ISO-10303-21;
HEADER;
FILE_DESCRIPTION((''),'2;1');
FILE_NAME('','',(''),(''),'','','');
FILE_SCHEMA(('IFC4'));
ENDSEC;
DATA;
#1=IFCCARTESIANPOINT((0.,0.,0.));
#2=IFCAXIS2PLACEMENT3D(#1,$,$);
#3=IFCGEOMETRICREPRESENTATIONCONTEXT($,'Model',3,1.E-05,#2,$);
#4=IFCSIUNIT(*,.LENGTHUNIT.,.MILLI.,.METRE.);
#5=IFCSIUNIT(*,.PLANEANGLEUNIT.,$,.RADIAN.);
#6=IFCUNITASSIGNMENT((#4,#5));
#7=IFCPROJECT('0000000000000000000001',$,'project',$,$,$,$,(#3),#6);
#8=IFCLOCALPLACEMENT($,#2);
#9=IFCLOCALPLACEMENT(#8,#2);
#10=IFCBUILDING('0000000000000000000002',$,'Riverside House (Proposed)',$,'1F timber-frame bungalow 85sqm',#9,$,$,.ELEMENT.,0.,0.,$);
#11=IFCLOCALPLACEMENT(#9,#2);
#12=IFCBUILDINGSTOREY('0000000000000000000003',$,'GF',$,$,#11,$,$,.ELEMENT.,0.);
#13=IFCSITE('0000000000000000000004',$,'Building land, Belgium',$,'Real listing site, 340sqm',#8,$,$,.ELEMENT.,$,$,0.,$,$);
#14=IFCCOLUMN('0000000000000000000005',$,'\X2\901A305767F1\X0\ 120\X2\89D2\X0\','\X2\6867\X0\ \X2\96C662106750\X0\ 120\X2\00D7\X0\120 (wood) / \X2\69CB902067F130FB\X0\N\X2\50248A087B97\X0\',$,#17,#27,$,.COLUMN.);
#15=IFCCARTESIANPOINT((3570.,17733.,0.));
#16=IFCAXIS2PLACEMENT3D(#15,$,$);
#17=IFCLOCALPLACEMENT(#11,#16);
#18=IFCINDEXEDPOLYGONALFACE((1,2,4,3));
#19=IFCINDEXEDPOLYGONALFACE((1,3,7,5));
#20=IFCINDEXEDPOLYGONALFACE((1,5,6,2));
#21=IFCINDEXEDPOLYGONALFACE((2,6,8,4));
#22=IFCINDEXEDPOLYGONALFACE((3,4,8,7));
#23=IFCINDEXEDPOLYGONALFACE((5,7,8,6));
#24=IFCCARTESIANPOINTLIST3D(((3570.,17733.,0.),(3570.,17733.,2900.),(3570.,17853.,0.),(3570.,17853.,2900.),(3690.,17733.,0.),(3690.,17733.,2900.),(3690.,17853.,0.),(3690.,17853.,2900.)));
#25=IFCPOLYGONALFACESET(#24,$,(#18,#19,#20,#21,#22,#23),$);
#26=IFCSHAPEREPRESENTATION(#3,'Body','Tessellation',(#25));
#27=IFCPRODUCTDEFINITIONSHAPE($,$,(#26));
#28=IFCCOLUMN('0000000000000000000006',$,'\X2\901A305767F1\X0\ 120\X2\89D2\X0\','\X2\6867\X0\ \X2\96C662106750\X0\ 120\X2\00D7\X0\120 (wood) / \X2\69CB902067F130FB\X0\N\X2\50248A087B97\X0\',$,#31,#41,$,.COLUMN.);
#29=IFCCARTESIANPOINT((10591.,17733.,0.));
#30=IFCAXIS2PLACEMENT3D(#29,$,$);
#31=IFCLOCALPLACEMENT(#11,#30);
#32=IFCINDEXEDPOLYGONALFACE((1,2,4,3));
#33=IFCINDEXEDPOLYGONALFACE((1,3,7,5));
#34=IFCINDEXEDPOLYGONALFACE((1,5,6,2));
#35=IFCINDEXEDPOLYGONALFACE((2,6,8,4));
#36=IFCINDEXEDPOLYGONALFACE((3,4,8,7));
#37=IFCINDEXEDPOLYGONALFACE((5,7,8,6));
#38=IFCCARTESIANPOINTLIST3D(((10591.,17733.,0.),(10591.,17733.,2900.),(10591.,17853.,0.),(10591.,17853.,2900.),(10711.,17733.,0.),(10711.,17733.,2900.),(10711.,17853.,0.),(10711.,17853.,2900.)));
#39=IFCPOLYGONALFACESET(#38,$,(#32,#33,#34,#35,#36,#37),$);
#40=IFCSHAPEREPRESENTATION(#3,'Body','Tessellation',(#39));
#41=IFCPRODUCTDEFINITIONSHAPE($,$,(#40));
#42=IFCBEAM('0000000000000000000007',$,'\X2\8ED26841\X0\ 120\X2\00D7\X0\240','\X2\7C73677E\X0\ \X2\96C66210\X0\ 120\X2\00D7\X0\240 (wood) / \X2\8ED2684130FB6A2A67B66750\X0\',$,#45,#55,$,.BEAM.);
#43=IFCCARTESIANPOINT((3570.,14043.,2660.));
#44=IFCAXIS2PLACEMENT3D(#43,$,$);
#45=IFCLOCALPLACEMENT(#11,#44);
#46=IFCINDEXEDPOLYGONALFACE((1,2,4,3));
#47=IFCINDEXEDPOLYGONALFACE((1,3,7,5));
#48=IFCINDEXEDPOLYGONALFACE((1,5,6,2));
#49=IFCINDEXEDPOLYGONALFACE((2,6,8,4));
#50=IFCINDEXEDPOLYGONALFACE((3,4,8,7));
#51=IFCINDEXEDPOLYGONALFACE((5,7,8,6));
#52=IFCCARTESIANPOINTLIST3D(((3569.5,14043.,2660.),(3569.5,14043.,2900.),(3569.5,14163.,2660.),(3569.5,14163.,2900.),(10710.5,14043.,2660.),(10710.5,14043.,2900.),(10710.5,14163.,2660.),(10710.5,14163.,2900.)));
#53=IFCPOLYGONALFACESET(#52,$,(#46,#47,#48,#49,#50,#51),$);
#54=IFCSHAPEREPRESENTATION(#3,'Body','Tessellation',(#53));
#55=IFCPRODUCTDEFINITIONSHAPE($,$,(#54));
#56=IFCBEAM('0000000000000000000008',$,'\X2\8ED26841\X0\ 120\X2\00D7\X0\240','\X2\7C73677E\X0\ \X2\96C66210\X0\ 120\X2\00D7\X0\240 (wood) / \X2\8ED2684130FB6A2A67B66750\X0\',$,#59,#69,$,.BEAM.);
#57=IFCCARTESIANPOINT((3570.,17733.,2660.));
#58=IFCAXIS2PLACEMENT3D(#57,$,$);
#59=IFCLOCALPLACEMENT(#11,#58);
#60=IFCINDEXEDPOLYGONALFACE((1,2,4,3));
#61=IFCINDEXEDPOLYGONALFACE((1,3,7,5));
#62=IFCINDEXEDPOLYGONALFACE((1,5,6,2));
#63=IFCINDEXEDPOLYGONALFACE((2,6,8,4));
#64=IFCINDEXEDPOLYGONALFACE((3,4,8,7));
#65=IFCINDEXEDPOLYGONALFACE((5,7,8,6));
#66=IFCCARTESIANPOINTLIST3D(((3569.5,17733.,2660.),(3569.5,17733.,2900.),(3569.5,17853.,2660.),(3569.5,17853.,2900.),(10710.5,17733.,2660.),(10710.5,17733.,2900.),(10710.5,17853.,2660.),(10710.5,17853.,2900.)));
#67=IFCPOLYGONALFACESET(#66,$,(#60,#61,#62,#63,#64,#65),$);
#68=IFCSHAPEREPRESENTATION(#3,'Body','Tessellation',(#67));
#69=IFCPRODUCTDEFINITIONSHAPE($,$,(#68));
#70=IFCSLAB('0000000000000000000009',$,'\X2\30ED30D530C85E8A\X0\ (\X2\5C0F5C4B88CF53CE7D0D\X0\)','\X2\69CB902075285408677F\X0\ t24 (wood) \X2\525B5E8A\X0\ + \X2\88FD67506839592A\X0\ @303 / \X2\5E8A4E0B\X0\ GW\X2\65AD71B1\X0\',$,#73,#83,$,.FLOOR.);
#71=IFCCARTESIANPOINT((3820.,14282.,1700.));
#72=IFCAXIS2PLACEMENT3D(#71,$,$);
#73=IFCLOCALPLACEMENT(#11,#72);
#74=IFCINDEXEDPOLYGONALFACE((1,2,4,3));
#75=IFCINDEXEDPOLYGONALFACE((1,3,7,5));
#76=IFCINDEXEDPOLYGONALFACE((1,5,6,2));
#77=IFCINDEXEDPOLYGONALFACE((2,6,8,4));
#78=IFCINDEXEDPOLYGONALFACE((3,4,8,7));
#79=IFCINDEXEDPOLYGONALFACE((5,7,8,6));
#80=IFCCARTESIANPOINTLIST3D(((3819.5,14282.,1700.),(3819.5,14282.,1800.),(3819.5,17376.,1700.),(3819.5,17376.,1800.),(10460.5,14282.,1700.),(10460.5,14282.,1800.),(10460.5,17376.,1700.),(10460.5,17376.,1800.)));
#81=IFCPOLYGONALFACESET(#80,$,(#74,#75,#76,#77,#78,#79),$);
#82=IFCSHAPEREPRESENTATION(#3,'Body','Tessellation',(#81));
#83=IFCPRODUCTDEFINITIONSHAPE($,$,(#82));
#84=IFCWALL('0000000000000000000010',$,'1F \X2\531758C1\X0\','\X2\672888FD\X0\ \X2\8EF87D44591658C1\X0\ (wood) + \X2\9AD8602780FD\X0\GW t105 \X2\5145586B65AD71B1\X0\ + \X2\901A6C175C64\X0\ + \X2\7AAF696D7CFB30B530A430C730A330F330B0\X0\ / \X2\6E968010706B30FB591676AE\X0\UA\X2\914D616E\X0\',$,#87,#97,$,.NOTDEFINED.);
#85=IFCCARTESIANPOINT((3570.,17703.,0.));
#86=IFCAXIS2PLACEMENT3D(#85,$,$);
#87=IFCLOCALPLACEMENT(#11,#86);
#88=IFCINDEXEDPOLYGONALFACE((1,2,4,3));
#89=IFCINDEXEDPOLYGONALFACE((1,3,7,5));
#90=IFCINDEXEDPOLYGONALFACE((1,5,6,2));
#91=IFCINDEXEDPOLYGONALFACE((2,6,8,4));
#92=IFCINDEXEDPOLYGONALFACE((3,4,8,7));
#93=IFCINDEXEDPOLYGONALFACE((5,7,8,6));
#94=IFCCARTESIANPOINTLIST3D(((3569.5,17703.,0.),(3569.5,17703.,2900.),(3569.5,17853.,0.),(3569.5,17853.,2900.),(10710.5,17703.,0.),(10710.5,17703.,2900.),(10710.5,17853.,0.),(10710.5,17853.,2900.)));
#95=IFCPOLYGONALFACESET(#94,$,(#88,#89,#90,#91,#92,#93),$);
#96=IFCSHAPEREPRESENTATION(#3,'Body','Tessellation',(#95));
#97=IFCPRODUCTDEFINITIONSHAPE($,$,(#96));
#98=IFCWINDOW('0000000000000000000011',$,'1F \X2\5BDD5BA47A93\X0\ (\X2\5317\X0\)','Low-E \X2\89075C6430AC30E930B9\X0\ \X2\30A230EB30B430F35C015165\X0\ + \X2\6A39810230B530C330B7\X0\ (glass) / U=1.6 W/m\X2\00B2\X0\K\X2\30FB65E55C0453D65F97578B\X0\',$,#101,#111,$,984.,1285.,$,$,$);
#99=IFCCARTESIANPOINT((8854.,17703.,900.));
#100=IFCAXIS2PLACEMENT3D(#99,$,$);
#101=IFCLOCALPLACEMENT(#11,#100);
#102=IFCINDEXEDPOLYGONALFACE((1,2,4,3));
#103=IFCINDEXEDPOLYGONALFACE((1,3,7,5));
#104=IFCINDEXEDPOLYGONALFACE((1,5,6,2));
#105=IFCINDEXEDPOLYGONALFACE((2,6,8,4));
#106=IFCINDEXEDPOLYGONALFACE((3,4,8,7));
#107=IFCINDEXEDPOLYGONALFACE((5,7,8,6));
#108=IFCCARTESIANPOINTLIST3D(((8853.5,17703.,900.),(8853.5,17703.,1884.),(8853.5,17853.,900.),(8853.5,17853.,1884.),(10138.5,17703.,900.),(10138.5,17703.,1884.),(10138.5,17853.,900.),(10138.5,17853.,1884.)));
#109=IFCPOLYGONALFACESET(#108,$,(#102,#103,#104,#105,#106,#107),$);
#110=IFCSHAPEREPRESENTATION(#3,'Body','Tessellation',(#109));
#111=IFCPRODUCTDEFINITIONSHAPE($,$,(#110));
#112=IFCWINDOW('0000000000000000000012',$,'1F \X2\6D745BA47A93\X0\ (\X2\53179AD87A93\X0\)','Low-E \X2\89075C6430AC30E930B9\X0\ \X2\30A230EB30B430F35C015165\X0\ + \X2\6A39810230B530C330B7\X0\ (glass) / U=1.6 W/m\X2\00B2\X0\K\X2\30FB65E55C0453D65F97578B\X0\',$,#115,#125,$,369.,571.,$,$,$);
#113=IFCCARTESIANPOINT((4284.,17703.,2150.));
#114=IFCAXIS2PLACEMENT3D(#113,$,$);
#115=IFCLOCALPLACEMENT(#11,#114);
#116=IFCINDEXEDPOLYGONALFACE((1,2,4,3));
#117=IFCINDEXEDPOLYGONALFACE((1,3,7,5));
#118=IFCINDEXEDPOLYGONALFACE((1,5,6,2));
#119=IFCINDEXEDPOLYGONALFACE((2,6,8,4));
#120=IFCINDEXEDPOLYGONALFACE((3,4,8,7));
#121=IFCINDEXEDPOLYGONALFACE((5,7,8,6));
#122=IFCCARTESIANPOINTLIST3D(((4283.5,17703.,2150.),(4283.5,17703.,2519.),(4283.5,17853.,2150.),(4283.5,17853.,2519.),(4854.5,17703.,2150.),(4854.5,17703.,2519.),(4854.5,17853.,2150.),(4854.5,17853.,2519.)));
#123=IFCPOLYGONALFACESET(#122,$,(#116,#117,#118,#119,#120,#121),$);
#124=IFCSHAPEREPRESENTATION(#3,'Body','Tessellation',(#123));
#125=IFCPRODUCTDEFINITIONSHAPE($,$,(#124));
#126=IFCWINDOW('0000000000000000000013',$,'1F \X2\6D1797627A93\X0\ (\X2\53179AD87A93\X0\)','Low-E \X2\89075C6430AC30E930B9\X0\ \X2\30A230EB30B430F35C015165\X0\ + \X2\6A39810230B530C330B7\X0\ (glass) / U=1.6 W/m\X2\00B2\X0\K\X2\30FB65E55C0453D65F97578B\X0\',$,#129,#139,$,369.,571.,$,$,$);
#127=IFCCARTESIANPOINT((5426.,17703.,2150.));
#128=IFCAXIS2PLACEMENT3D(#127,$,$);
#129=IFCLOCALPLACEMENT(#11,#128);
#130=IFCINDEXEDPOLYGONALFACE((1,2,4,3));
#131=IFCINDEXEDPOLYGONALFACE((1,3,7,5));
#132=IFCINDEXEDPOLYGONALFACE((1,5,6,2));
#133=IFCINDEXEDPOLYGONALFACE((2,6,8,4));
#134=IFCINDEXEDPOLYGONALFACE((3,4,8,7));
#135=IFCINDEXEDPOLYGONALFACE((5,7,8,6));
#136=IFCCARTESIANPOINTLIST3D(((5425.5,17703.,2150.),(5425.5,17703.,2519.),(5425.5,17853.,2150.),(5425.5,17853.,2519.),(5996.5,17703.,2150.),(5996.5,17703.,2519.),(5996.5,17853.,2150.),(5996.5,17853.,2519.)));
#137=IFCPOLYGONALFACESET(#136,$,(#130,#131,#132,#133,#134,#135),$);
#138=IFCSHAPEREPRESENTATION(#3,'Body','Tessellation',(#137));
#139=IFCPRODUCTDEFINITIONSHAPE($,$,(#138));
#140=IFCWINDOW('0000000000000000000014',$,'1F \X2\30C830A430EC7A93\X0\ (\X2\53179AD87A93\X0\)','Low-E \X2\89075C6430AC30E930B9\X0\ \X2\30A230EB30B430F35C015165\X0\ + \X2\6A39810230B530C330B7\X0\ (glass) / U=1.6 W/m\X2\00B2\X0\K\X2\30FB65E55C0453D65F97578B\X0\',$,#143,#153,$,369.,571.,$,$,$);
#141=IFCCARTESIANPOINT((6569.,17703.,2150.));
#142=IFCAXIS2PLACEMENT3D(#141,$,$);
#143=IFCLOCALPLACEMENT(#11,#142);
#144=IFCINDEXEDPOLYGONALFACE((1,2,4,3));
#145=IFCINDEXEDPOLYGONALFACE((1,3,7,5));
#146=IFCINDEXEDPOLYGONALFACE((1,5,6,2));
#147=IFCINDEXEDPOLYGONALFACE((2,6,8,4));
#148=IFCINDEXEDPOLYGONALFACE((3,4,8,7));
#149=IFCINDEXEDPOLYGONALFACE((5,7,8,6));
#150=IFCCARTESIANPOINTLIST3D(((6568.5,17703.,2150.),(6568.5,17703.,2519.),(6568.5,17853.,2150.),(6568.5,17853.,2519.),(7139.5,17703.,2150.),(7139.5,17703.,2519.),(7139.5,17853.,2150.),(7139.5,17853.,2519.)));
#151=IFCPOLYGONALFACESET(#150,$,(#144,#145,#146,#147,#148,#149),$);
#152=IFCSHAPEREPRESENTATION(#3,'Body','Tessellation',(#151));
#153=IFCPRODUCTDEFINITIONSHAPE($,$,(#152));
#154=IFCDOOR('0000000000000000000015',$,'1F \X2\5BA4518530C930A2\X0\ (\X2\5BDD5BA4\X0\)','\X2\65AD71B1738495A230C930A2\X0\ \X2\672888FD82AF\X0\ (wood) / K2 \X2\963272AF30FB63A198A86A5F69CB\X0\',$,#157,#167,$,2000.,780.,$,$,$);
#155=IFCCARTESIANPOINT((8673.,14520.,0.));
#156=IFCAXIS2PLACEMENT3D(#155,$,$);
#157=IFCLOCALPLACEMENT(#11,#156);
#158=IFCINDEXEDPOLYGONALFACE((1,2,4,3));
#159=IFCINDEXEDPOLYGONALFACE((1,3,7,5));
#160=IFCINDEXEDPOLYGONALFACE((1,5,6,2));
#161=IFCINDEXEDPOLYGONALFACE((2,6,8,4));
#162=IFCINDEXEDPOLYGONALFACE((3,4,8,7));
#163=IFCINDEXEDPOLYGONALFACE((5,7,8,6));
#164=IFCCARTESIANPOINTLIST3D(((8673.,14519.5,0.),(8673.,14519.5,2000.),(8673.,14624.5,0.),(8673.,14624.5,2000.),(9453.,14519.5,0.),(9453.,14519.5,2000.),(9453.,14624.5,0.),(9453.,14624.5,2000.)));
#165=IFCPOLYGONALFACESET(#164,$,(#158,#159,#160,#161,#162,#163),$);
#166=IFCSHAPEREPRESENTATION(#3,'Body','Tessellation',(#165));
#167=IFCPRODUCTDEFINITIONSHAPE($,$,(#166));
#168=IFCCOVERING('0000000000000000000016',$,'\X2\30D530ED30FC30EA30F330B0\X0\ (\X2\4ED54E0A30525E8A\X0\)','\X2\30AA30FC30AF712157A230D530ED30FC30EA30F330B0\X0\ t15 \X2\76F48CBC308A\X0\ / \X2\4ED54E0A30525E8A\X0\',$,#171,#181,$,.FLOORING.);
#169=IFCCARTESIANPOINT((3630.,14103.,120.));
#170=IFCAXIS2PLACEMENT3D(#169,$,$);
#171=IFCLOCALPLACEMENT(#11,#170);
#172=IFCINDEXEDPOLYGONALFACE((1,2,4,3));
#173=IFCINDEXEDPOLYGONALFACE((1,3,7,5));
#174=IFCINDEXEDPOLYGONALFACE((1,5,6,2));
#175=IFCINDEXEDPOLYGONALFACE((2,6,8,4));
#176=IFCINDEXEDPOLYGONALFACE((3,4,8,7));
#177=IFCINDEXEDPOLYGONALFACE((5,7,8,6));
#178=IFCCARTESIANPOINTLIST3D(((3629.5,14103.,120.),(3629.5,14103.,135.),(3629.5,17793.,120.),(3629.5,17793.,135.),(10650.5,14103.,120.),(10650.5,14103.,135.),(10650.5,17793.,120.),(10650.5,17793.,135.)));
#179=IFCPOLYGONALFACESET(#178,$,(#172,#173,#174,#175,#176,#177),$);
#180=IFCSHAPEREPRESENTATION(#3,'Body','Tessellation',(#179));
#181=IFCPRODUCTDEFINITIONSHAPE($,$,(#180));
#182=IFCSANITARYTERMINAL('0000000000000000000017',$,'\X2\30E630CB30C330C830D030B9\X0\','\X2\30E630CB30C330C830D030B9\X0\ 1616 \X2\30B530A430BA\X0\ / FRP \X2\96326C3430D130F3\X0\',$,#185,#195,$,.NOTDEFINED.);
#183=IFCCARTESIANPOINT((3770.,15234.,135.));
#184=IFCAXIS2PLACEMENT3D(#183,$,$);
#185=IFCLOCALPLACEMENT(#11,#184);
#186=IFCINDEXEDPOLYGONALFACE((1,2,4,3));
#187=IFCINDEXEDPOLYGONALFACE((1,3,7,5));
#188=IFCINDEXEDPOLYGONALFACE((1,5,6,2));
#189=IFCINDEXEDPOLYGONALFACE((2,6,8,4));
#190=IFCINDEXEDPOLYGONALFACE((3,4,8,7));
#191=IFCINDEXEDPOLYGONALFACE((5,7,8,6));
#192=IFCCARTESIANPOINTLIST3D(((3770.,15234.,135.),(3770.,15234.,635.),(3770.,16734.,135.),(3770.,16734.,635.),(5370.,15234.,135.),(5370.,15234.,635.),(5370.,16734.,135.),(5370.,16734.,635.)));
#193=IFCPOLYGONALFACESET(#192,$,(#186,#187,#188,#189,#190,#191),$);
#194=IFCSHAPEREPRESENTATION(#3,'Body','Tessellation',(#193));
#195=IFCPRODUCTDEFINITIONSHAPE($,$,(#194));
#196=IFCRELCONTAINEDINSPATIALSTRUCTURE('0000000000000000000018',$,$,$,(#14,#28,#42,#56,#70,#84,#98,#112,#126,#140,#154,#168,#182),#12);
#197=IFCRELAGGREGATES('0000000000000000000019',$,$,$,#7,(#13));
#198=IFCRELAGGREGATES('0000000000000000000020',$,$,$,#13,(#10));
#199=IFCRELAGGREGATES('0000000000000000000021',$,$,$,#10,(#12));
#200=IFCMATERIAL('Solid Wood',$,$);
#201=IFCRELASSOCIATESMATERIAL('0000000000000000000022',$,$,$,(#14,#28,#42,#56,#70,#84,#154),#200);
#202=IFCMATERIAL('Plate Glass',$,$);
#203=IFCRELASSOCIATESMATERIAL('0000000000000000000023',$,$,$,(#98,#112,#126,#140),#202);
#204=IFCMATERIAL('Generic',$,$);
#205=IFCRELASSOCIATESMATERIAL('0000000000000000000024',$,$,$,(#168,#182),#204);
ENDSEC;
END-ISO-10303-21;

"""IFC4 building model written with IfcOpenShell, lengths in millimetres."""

from ifc_helpers import new_model, si_unit, frame, frame_2d, origin, place, context, project, spatial, rectangle, extrude, material, element, fill, save


model = new_model("IFC4")

# Units and contexts
model_context = context("Model", 3, precision=1e-05, world=origin())
ifc_project = project(units=[si_unit("LENGTHUNIT", "METRE", prefix="MILLI"), si_unit("PLANEANGLEUNIT", "RADIAN")], contexts=[model_context])

# Site, building, storey
site_placement = place(None, origin())
site = spatial("IfcSite", under=ifc_project, at=site_placement, Name="Building land, Belgium", ObjectType="Real listing site, 340sqm", CompositionType="ELEMENT", RefElevation=0.0)
building_placement = place(site_placement, origin())
building = spatial("IfcBuilding", under=site, at=building_placement, Name="Riverside House (Proposed)", ObjectType="1F timber-frame bungalow 85sqm", CompositionType="ELEMENT", ElevationOfRefHeight=0.0, ElevationOfTerrain=0.0)
storey_placement = place(building_placement, origin())
storey = spatial("IfcBuildingStorey", under=building, at=storey_placement, Name="GF", CompositionType="ELEMENT", Elevation=0.0)

# Columns
ifc_material_1 = material(Name="Solid Wood")
column_1_placement = place(storey_placement, frame((3570.0, 17733.0, 0.0)))
element("IfcColumn", 1, at=column_1_placement, inside=storey, material=ifc_material_1, Name="通し柱 120角", Description="桧 集成材 120×120 (wood) / 構造柱・N値計算", PredefinedType="COLUMN", context=model_context, shape_type="SweptSolid", body=[
    extrude(rectangle(XDim=120.0, YDim=120.0, at=frame_2d((60.0, 60.0))), frame((3570.0, 17733.0, 0.0)), (0.0, 0.0, 1.0), 2900.0),
])
column_2_placement = place(storey_placement, frame((10591.0, 17733.0, 0.0)))
element("IfcColumn", 2, at=column_2_placement, inside=storey, material=ifc_material_1, Name="通し柱 120角", Description="桧 集成材 120×120 (wood) / 構造柱・N値計算", PredefinedType="COLUMN", context=model_context, shape_type="SweptSolid", body=[
    extrude(rectangle(XDim=120.0, YDim=120.0, at=frame_2d((60.0, 60.0))), frame((10591.0, 17733.0, 0.0)), (0.0, 0.0, 1.0), 2900.0),
])

# Beams
beam_1_placement = place(storey_placement, frame((3570.0, 14043.0, 2660.0)))
element("IfcBeam", 3, at=beam_1_placement, inside=storey, material=ifc_material_1, Name="軒桁 120×240", Description="米松 集成 120×240 (wood) / 軒桁・横架材", PredefinedType="BEAM", context=model_context, shape_type="SweptSolid", body=[
    extrude(rectangle(XDim=7141.0, YDim=120.0, at=frame_2d((3570.0, 60.0))), frame((3570.0, 14043.0, 2660.0)), (0.0, 0.0, 1.0), 240.0),
])
beam_2_placement = place(storey_placement, frame((3570.0, 17733.0, 2660.0)))
element("IfcBeam", 4, at=beam_2_placement, inside=storey, material=ifc_material_1, Name="軒桁 120×240", Description="米松 集成 120×240 (wood) / 軒桁・横架材", PredefinedType="BEAM", context=model_context, shape_type="SweptSolid", body=[
    extrude(rectangle(XDim=7141.0, YDim=120.0, at=frame_2d((3570.0, 60.0))), frame((3570.0, 17733.0, 2660.0)), (0.0, 0.0, 1.0), 240.0),
])

# Slab
slab_placement = place(storey_placement, frame((3820.0, 14282.0, 1700.0)))
element("IfcSlab", 5, at=slab_placement, inside=storey, material=ifc_material_1, Name="ロフト床 (小屋裏収納)", Description="構造用合板 t24 (wood) 剛床 + 製材根太 @303 / 床下 GW断熱", PredefinedType="FLOOR", context=model_context, shape_type="SweptSolid", body=[
    extrude(rectangle(XDim=6641.0, YDim=3094.0, at=frame_2d((3320.0, 1547.0))), frame((3820.0, 14282.0, 1700.0)), (0.0, 0.0, 1.0), 100.0),
])

# Wall, openings, windows
wall_1_placement = place(storey_placement, frame((3570.0, 17703.0, 0.0)))
wall_1 = element("IfcWall", 6, at=wall_1_placement, inside=storey, material=ifc_material_1, Name="1F 北壁", Description="木製 軸組外壁 (wood) + 高性能GW t105 充填断熱 + 通気層 + 窯業系サイディング / 準耐火・外皮UA配慮", PredefinedType="NOTDEFINED", context=model_context, shape_type="SweptSolid", body=[
    extrude(rectangle(XDim=7141.0, YDim=150.0, at=frame_2d((3570.0, 75.0))), frame((3570.0, 17703.0, 0.0)), (0.0, 0.0, 1.0), 2900.0),
])
opening_1_placement = place(storey_placement, frame((8854.0, 17703.0, 900.0)))
opening_1 = element("IfcOpeningElement", 7, at=opening_1_placement, cuts=wall_1, PredefinedType="NOTDEFINED", context=model_context, shape_type="SweptSolid", body=[
    extrude(rectangle(XDim=1285.0, YDim=150.0, at=frame_2d((642.0, 75.0))), frame((8854.0, 17703.0, 900.0)), (0.0, 0.0, 1.0), 984.0),
])
opening_2_placement = place(storey_placement, frame((4284.0, 17703.0, 2150.0)))
opening_2 = element("IfcOpeningElement", 8, at=opening_2_placement, cuts=wall_1, PredefinedType="NOTDEFINED", context=model_context, shape_type="SweptSolid", body=[
    extrude(rectangle(XDim=571.0, YDim=150.0, at=frame_2d((285.0, 75.0))), frame((4284.0, 17703.0, 2150.0)), (0.0, 0.0, 1.0), 369.0),
])
opening_3_placement = place(storey_placement, frame((5426.0, 17703.0, 2150.0)))
opening_3 = element("IfcOpeningElement", 9, at=opening_3_placement, cuts=wall_1, PredefinedType="NOTDEFINED", context=model_context, shape_type="SweptSolid", body=[
    extrude(rectangle(XDim=571.0, YDim=150.0, at=frame_2d((285.0, 75.0))), frame((5426.0, 17703.0, 2150.0)), (0.0, 0.0, 1.0), 369.0),
])
opening_4_placement = place(storey_placement, frame((6569.0, 17703.0, 2150.0)))
opening_4 = element("IfcOpeningElement", 10, at=opening_4_placement, cuts=wall_1, PredefinedType="NOTDEFINED", context=model_context, shape_type="SweptSolid", body=[
    extrude(rectangle(XDim=571.0, YDim=150.0, at=frame_2d((285.0, 75.0))), frame((6569.0, 17703.0, 2150.0)), (0.0, 0.0, 1.0), 369.0),
])
ifc_material_2 = material(Name="Plate Glass")
window_1_placement = place(storey_placement, frame((8854.0, 17703.0, 900.0)))
window_1 = element("IfcWindow", 11, at=window_1_placement, inside=storey, material=ifc_material_2, Name="1F 寝室窓 (北)", Description="Low-E 複層ガラス アルゴン封入 + 樹脂サッシ (glass) / U=1.6 W/m²K・日射取得型", OverallHeight=984.0, OverallWidth=1285.0, context=model_context, shape_type="SweptSolid", body=[
    extrude(rectangle(XDim=1285.0, YDim=150.0, at=frame_2d((642.0, 75.0))), frame((8854.0, 17703.0, 900.0)), (0.0, 0.0, 1.0), 984.0),
])
fill(opening_1, window_1)
window_2_placement = place(storey_placement, frame((4284.0, 17703.0, 2150.0)))
window_2 = element("IfcWindow", 12, at=window_2_placement, inside=storey, material=ifc_material_2, Name="1F 浴室窓 (北高窓)", Description="Low-E 複層ガラス アルゴン封入 + 樹脂サッシ (glass) / U=1.6 W/m²K・日射取得型", OverallHeight=369.0, OverallWidth=571.0, context=model_context, shape_type="SweptSolid", body=[
    extrude(rectangle(XDim=571.0, YDim=150.0, at=frame_2d((285.0, 75.0))), frame((4284.0, 17703.0, 2150.0)), (0.0, 0.0, 1.0), 369.0),
])
fill(opening_2, window_2)
window_3_placement = place(storey_placement, frame((5426.0, 17703.0, 2150.0)))
window_3 = element("IfcWindow", 13, at=window_3_placement, inside=storey, material=ifc_material_2, Name="1F 洗面窓 (北高窓)", Description="Low-E 複層ガラス アルゴン封入 + 樹脂サッシ (glass) / U=1.6 W/m²K・日射取得型", OverallHeight=369.0, OverallWidth=571.0, context=model_context, shape_type="SweptSolid", body=[
    extrude(rectangle(XDim=571.0, YDim=150.0, at=frame_2d((285.0, 75.0))), frame((5426.0, 17703.0, 2150.0)), (0.0, 0.0, 1.0), 369.0),
])
fill(opening_3, window_3)
window_4_placement = place(storey_placement, frame((6569.0, 17703.0, 2150.0)))
window_4 = element("IfcWindow", 14, at=window_4_placement, inside=storey, material=ifc_material_2, Name="1F トイレ窓 (北高窓)", Description="Low-E 複層ガラス アルゴン封入 + 樹脂サッシ (glass) / U=1.6 W/m²K・日射取得型", OverallHeight=369.0, OverallWidth=571.0, context=model_context, shape_type="SweptSolid", body=[
    extrude(rectangle(XDim=571.0, YDim=150.0, at=frame_2d((285.0, 75.0))), frame((6569.0, 17703.0, 2150.0)), (0.0, 0.0, 1.0), 369.0),
])
fill(opening_4, window_4)

# Door
door_1_placement = place(storey_placement, frame((8673.0, 14520.0, 0.0)))
element("IfcDoor", 15, at=door_1_placement, inside=storey, material=ifc_material_1, Name="1F 室内ドア (寝室)", Description="断熱玄関ドア 木製芯 (wood) / K2 防犯・採風機構", OverallHeight=2000.0, OverallWidth=780.0, context=model_context, shape_type="SweptSolid", body=[
    extrude(rectangle(XDim=780.0, YDim=105.0, at=frame_2d((390.0, 52.0))), frame((8673.0, 14520.0, 0.0)), (0.0, 0.0, 1.0), 2000.0),
])

# Covering
ifc_material_3 = material(Name="Generic")
covering_placement = place(storey_placement, frame((3630.0, 14103.0, 120.0)))
element("IfcCovering", 16, at=covering_placement, inside=storey, material=ifc_material_3, Name="フローリング (仕上げ床)", Description="オーク無垢フローリング t15 直貼り / 仕上げ床", PredefinedType="FLOORING", context=model_context, shape_type="SweptSolid", body=[
    extrude(rectangle(XDim=7021.0, YDim=3690.0, at=frame_2d((3510.0, 1845.0))), frame((3630.0, 14103.0, 120.0)), (0.0, 0.0, 1.0), 15.0),
])

# Sanitary terminal
sanitary_terminal_1_placement = place(storey_placement, frame((3770.0, 15234.0, 135.0)))
element("IfcSanitaryTerminal", 17, at=sanitary_terminal_1_placement, inside=storey, material=ifc_material_3, Name="ユニットバス", Description="ユニットバス 1616 サイズ / FRP 防水パン", PredefinedType="NOTDEFINED", context=model_context, shape_type="SweptSolid", body=[
    extrude(rectangle(XDim=1600.0, YDim=1500.0, at=frame_2d((800.0, 750.0))), frame((3770.0, 15234.0, 135.0)), (0.0, 0.0, 1.0), 500.0),
])

save(model, "model.ifc")
